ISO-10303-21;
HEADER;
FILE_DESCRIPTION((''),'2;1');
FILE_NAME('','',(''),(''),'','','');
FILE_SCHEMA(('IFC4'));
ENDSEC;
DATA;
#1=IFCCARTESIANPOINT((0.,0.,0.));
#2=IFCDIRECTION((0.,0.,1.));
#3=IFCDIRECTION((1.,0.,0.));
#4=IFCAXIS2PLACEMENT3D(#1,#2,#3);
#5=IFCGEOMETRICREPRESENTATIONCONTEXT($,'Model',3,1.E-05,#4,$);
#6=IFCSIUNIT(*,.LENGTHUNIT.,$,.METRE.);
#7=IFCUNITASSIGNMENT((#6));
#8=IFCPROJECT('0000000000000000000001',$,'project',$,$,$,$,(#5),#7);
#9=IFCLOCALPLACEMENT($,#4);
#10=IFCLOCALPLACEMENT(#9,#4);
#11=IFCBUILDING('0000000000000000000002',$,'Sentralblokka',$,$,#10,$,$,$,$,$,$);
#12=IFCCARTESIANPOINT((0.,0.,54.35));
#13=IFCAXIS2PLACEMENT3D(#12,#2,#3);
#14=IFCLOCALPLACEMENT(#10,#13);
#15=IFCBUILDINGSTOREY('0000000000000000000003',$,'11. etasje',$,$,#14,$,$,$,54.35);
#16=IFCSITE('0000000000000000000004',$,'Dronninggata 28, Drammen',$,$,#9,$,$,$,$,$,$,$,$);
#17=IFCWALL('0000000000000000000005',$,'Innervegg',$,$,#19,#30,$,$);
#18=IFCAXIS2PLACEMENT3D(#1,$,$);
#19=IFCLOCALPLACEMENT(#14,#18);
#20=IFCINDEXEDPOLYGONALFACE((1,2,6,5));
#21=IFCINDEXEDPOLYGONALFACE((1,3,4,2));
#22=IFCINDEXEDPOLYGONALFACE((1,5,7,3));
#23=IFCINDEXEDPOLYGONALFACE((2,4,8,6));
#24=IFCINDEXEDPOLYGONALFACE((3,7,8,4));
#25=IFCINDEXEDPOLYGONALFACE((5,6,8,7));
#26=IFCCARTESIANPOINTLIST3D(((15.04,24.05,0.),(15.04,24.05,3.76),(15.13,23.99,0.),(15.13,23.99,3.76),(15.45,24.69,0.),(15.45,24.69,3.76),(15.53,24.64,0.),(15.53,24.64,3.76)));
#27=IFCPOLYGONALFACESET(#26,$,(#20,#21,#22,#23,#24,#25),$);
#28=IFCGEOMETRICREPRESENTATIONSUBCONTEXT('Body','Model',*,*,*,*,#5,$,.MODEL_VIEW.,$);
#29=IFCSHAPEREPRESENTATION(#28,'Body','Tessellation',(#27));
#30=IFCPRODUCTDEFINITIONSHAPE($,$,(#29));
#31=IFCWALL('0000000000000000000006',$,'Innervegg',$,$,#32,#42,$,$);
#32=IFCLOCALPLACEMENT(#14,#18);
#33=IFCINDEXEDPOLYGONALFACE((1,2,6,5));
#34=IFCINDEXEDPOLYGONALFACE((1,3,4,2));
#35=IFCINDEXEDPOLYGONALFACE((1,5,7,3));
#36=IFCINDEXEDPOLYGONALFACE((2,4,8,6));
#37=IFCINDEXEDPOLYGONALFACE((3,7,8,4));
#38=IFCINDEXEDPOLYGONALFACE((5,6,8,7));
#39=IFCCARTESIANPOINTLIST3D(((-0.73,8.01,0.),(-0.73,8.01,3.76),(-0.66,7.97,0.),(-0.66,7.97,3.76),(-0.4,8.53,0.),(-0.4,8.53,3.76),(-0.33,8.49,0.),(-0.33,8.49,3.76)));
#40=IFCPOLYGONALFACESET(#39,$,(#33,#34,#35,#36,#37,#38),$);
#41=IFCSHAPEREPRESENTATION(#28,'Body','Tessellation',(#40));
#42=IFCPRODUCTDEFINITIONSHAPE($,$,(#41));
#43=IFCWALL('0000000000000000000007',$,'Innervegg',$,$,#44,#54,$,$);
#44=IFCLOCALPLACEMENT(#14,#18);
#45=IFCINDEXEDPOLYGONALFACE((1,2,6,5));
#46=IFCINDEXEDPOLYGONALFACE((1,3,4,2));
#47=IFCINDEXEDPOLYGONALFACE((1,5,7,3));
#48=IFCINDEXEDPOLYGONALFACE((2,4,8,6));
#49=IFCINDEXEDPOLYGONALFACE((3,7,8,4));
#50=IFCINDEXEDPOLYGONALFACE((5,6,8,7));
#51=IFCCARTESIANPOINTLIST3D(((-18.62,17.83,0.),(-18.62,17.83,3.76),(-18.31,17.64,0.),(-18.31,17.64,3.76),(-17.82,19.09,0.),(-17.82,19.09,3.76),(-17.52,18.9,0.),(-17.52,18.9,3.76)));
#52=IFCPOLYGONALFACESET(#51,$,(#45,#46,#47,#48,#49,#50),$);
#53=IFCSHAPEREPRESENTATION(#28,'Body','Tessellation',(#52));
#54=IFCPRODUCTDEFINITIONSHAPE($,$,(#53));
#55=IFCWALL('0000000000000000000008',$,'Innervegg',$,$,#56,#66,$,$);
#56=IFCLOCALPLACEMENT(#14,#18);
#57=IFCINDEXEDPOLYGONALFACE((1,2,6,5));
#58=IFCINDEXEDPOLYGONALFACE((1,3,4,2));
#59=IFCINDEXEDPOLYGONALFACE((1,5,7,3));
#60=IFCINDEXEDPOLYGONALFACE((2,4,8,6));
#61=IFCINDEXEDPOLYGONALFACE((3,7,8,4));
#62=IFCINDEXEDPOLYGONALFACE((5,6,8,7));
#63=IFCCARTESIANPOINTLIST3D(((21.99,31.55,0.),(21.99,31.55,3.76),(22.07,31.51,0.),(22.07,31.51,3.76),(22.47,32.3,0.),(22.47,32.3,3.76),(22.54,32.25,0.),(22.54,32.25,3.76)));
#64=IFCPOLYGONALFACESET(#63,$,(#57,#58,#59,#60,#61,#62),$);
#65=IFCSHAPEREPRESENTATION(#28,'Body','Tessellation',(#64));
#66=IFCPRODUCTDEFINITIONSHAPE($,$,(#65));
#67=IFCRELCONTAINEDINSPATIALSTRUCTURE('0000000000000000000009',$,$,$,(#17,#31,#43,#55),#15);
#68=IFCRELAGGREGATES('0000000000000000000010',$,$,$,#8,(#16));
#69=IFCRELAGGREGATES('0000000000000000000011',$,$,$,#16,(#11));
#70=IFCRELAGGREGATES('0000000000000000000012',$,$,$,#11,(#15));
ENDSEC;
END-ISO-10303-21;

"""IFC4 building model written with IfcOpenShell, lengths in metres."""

from ifc_helpers import new_model, si_unit, frame, origin_with_axes, place, context, subcontext, project, spatial, polyline, outline, extrude, element, save


model = new_model("IFC4")

# Units and contexts
model_context = context("Model", 3, precision=1e-05, world=origin_with_axes())
body_context = subcontext(model_context, "Body", "Model", "MODEL_VIEW")
ifc_project = project(units=[si_unit("LENGTHUNIT", "METRE")], contexts=[model_context])

# Site, building, storey
site_placement = place(None, origin_with_axes())
site = spatial("IfcSite", under=ifc_project, at=site_placement, Name="Dronninggata 28, Drammen")
building_placement = place(site_placement, origin_with_axes())
building = spatial("IfcBuilding", under=site, at=building_placement, Name="Sentralblokka")
storey_placement = place(building_placement, frame((0.0, 0.0, 54.35), z_axis=(0.0, 0.0, 1.0), x_axis=(1.0, 0.0, 0.0)))
storey = spatial("IfcBuildingStorey", under=building, at=storey_placement, Name="11. etasje", Elevation=54.35)

# Walls
wall_1_placement = place(storey_placement, frame((0.0, 0.0, -54.35), z_axis=(0.0, 0.0, 1.0), x_axis=(1.0, 0.0, 0.0)))
element("IfcWall", 1, at=wall_1_placement, inside=storey, Name="Innervegg", context=body_context, shape_type="SweptSolid", body=[
    extrude(outline(polyline([(15.53, 24.64), (15.13, 23.99), (15.04, 24.05), (15.45, 24.69), (15.53, 24.64)])), frame((0.0, 0.0, 54.35)), (0.0, 0.0, 1.0), 3.76),
])
wall_2_placement = place(storey_placement, frame((0.0, 0.0, -54.35), z_axis=(0.0, 0.0, 1.0), x_axis=(1.0, 0.0, 0.0)))
element("IfcWall", 2, at=wall_2_placement, inside=storey, Name="Innervegg", context=body_context, shape_type="SweptSolid", body=[
    extrude(outline(polyline([(-0.33, 8.49), (-0.66, 7.97), (-0.73, 8.01), (-0.4, 8.53), (-0.33, 8.49)])), frame((0.0, 0.0, 54.35)), (0.0, 0.0, 1.0), 3.76),
])
wall_3_placement = place(storey_placement, frame((0.0, 0.0, -54.35), z_axis=(0.0, 0.0, 1.0), x_axis=(1.0, 0.0, 0.0)))
element("IfcWall", 3, at=wall_3_placement, inside=storey, Name="Innervegg", context=body_context, shape_type="SweptSolid", body=[
    extrude(outline(polyline([(-17.52, 18.9), (-18.31, 17.64), (-18.62, 17.83), (-17.82, 19.09), (-17.52, 18.9)])), frame((0.0, 0.0, 54.35)), (0.0, 0.0, 1.0), 3.76),
])
wall_4_placement = place(storey_placement, frame((0.0, 0.0, -54.35), z_axis=(0.0, 0.0, 1.0), x_axis=(1.0, 0.0, 0.0)))
element("IfcWall", 4, at=wall_4_placement, inside=storey, Name="Innervegg", context=body_context, shape_type="SweptSolid", body=[
    extrude(outline(polyline([(22.54, 32.25), (22.07, 31.51), (21.99, 31.55), (22.47, 32.3), (22.54, 32.25)])), frame((0.0, 0.0, 54.35)), (0.0, 0.0, 1.0), 3.76),
])

save(model, "model.ifc")
